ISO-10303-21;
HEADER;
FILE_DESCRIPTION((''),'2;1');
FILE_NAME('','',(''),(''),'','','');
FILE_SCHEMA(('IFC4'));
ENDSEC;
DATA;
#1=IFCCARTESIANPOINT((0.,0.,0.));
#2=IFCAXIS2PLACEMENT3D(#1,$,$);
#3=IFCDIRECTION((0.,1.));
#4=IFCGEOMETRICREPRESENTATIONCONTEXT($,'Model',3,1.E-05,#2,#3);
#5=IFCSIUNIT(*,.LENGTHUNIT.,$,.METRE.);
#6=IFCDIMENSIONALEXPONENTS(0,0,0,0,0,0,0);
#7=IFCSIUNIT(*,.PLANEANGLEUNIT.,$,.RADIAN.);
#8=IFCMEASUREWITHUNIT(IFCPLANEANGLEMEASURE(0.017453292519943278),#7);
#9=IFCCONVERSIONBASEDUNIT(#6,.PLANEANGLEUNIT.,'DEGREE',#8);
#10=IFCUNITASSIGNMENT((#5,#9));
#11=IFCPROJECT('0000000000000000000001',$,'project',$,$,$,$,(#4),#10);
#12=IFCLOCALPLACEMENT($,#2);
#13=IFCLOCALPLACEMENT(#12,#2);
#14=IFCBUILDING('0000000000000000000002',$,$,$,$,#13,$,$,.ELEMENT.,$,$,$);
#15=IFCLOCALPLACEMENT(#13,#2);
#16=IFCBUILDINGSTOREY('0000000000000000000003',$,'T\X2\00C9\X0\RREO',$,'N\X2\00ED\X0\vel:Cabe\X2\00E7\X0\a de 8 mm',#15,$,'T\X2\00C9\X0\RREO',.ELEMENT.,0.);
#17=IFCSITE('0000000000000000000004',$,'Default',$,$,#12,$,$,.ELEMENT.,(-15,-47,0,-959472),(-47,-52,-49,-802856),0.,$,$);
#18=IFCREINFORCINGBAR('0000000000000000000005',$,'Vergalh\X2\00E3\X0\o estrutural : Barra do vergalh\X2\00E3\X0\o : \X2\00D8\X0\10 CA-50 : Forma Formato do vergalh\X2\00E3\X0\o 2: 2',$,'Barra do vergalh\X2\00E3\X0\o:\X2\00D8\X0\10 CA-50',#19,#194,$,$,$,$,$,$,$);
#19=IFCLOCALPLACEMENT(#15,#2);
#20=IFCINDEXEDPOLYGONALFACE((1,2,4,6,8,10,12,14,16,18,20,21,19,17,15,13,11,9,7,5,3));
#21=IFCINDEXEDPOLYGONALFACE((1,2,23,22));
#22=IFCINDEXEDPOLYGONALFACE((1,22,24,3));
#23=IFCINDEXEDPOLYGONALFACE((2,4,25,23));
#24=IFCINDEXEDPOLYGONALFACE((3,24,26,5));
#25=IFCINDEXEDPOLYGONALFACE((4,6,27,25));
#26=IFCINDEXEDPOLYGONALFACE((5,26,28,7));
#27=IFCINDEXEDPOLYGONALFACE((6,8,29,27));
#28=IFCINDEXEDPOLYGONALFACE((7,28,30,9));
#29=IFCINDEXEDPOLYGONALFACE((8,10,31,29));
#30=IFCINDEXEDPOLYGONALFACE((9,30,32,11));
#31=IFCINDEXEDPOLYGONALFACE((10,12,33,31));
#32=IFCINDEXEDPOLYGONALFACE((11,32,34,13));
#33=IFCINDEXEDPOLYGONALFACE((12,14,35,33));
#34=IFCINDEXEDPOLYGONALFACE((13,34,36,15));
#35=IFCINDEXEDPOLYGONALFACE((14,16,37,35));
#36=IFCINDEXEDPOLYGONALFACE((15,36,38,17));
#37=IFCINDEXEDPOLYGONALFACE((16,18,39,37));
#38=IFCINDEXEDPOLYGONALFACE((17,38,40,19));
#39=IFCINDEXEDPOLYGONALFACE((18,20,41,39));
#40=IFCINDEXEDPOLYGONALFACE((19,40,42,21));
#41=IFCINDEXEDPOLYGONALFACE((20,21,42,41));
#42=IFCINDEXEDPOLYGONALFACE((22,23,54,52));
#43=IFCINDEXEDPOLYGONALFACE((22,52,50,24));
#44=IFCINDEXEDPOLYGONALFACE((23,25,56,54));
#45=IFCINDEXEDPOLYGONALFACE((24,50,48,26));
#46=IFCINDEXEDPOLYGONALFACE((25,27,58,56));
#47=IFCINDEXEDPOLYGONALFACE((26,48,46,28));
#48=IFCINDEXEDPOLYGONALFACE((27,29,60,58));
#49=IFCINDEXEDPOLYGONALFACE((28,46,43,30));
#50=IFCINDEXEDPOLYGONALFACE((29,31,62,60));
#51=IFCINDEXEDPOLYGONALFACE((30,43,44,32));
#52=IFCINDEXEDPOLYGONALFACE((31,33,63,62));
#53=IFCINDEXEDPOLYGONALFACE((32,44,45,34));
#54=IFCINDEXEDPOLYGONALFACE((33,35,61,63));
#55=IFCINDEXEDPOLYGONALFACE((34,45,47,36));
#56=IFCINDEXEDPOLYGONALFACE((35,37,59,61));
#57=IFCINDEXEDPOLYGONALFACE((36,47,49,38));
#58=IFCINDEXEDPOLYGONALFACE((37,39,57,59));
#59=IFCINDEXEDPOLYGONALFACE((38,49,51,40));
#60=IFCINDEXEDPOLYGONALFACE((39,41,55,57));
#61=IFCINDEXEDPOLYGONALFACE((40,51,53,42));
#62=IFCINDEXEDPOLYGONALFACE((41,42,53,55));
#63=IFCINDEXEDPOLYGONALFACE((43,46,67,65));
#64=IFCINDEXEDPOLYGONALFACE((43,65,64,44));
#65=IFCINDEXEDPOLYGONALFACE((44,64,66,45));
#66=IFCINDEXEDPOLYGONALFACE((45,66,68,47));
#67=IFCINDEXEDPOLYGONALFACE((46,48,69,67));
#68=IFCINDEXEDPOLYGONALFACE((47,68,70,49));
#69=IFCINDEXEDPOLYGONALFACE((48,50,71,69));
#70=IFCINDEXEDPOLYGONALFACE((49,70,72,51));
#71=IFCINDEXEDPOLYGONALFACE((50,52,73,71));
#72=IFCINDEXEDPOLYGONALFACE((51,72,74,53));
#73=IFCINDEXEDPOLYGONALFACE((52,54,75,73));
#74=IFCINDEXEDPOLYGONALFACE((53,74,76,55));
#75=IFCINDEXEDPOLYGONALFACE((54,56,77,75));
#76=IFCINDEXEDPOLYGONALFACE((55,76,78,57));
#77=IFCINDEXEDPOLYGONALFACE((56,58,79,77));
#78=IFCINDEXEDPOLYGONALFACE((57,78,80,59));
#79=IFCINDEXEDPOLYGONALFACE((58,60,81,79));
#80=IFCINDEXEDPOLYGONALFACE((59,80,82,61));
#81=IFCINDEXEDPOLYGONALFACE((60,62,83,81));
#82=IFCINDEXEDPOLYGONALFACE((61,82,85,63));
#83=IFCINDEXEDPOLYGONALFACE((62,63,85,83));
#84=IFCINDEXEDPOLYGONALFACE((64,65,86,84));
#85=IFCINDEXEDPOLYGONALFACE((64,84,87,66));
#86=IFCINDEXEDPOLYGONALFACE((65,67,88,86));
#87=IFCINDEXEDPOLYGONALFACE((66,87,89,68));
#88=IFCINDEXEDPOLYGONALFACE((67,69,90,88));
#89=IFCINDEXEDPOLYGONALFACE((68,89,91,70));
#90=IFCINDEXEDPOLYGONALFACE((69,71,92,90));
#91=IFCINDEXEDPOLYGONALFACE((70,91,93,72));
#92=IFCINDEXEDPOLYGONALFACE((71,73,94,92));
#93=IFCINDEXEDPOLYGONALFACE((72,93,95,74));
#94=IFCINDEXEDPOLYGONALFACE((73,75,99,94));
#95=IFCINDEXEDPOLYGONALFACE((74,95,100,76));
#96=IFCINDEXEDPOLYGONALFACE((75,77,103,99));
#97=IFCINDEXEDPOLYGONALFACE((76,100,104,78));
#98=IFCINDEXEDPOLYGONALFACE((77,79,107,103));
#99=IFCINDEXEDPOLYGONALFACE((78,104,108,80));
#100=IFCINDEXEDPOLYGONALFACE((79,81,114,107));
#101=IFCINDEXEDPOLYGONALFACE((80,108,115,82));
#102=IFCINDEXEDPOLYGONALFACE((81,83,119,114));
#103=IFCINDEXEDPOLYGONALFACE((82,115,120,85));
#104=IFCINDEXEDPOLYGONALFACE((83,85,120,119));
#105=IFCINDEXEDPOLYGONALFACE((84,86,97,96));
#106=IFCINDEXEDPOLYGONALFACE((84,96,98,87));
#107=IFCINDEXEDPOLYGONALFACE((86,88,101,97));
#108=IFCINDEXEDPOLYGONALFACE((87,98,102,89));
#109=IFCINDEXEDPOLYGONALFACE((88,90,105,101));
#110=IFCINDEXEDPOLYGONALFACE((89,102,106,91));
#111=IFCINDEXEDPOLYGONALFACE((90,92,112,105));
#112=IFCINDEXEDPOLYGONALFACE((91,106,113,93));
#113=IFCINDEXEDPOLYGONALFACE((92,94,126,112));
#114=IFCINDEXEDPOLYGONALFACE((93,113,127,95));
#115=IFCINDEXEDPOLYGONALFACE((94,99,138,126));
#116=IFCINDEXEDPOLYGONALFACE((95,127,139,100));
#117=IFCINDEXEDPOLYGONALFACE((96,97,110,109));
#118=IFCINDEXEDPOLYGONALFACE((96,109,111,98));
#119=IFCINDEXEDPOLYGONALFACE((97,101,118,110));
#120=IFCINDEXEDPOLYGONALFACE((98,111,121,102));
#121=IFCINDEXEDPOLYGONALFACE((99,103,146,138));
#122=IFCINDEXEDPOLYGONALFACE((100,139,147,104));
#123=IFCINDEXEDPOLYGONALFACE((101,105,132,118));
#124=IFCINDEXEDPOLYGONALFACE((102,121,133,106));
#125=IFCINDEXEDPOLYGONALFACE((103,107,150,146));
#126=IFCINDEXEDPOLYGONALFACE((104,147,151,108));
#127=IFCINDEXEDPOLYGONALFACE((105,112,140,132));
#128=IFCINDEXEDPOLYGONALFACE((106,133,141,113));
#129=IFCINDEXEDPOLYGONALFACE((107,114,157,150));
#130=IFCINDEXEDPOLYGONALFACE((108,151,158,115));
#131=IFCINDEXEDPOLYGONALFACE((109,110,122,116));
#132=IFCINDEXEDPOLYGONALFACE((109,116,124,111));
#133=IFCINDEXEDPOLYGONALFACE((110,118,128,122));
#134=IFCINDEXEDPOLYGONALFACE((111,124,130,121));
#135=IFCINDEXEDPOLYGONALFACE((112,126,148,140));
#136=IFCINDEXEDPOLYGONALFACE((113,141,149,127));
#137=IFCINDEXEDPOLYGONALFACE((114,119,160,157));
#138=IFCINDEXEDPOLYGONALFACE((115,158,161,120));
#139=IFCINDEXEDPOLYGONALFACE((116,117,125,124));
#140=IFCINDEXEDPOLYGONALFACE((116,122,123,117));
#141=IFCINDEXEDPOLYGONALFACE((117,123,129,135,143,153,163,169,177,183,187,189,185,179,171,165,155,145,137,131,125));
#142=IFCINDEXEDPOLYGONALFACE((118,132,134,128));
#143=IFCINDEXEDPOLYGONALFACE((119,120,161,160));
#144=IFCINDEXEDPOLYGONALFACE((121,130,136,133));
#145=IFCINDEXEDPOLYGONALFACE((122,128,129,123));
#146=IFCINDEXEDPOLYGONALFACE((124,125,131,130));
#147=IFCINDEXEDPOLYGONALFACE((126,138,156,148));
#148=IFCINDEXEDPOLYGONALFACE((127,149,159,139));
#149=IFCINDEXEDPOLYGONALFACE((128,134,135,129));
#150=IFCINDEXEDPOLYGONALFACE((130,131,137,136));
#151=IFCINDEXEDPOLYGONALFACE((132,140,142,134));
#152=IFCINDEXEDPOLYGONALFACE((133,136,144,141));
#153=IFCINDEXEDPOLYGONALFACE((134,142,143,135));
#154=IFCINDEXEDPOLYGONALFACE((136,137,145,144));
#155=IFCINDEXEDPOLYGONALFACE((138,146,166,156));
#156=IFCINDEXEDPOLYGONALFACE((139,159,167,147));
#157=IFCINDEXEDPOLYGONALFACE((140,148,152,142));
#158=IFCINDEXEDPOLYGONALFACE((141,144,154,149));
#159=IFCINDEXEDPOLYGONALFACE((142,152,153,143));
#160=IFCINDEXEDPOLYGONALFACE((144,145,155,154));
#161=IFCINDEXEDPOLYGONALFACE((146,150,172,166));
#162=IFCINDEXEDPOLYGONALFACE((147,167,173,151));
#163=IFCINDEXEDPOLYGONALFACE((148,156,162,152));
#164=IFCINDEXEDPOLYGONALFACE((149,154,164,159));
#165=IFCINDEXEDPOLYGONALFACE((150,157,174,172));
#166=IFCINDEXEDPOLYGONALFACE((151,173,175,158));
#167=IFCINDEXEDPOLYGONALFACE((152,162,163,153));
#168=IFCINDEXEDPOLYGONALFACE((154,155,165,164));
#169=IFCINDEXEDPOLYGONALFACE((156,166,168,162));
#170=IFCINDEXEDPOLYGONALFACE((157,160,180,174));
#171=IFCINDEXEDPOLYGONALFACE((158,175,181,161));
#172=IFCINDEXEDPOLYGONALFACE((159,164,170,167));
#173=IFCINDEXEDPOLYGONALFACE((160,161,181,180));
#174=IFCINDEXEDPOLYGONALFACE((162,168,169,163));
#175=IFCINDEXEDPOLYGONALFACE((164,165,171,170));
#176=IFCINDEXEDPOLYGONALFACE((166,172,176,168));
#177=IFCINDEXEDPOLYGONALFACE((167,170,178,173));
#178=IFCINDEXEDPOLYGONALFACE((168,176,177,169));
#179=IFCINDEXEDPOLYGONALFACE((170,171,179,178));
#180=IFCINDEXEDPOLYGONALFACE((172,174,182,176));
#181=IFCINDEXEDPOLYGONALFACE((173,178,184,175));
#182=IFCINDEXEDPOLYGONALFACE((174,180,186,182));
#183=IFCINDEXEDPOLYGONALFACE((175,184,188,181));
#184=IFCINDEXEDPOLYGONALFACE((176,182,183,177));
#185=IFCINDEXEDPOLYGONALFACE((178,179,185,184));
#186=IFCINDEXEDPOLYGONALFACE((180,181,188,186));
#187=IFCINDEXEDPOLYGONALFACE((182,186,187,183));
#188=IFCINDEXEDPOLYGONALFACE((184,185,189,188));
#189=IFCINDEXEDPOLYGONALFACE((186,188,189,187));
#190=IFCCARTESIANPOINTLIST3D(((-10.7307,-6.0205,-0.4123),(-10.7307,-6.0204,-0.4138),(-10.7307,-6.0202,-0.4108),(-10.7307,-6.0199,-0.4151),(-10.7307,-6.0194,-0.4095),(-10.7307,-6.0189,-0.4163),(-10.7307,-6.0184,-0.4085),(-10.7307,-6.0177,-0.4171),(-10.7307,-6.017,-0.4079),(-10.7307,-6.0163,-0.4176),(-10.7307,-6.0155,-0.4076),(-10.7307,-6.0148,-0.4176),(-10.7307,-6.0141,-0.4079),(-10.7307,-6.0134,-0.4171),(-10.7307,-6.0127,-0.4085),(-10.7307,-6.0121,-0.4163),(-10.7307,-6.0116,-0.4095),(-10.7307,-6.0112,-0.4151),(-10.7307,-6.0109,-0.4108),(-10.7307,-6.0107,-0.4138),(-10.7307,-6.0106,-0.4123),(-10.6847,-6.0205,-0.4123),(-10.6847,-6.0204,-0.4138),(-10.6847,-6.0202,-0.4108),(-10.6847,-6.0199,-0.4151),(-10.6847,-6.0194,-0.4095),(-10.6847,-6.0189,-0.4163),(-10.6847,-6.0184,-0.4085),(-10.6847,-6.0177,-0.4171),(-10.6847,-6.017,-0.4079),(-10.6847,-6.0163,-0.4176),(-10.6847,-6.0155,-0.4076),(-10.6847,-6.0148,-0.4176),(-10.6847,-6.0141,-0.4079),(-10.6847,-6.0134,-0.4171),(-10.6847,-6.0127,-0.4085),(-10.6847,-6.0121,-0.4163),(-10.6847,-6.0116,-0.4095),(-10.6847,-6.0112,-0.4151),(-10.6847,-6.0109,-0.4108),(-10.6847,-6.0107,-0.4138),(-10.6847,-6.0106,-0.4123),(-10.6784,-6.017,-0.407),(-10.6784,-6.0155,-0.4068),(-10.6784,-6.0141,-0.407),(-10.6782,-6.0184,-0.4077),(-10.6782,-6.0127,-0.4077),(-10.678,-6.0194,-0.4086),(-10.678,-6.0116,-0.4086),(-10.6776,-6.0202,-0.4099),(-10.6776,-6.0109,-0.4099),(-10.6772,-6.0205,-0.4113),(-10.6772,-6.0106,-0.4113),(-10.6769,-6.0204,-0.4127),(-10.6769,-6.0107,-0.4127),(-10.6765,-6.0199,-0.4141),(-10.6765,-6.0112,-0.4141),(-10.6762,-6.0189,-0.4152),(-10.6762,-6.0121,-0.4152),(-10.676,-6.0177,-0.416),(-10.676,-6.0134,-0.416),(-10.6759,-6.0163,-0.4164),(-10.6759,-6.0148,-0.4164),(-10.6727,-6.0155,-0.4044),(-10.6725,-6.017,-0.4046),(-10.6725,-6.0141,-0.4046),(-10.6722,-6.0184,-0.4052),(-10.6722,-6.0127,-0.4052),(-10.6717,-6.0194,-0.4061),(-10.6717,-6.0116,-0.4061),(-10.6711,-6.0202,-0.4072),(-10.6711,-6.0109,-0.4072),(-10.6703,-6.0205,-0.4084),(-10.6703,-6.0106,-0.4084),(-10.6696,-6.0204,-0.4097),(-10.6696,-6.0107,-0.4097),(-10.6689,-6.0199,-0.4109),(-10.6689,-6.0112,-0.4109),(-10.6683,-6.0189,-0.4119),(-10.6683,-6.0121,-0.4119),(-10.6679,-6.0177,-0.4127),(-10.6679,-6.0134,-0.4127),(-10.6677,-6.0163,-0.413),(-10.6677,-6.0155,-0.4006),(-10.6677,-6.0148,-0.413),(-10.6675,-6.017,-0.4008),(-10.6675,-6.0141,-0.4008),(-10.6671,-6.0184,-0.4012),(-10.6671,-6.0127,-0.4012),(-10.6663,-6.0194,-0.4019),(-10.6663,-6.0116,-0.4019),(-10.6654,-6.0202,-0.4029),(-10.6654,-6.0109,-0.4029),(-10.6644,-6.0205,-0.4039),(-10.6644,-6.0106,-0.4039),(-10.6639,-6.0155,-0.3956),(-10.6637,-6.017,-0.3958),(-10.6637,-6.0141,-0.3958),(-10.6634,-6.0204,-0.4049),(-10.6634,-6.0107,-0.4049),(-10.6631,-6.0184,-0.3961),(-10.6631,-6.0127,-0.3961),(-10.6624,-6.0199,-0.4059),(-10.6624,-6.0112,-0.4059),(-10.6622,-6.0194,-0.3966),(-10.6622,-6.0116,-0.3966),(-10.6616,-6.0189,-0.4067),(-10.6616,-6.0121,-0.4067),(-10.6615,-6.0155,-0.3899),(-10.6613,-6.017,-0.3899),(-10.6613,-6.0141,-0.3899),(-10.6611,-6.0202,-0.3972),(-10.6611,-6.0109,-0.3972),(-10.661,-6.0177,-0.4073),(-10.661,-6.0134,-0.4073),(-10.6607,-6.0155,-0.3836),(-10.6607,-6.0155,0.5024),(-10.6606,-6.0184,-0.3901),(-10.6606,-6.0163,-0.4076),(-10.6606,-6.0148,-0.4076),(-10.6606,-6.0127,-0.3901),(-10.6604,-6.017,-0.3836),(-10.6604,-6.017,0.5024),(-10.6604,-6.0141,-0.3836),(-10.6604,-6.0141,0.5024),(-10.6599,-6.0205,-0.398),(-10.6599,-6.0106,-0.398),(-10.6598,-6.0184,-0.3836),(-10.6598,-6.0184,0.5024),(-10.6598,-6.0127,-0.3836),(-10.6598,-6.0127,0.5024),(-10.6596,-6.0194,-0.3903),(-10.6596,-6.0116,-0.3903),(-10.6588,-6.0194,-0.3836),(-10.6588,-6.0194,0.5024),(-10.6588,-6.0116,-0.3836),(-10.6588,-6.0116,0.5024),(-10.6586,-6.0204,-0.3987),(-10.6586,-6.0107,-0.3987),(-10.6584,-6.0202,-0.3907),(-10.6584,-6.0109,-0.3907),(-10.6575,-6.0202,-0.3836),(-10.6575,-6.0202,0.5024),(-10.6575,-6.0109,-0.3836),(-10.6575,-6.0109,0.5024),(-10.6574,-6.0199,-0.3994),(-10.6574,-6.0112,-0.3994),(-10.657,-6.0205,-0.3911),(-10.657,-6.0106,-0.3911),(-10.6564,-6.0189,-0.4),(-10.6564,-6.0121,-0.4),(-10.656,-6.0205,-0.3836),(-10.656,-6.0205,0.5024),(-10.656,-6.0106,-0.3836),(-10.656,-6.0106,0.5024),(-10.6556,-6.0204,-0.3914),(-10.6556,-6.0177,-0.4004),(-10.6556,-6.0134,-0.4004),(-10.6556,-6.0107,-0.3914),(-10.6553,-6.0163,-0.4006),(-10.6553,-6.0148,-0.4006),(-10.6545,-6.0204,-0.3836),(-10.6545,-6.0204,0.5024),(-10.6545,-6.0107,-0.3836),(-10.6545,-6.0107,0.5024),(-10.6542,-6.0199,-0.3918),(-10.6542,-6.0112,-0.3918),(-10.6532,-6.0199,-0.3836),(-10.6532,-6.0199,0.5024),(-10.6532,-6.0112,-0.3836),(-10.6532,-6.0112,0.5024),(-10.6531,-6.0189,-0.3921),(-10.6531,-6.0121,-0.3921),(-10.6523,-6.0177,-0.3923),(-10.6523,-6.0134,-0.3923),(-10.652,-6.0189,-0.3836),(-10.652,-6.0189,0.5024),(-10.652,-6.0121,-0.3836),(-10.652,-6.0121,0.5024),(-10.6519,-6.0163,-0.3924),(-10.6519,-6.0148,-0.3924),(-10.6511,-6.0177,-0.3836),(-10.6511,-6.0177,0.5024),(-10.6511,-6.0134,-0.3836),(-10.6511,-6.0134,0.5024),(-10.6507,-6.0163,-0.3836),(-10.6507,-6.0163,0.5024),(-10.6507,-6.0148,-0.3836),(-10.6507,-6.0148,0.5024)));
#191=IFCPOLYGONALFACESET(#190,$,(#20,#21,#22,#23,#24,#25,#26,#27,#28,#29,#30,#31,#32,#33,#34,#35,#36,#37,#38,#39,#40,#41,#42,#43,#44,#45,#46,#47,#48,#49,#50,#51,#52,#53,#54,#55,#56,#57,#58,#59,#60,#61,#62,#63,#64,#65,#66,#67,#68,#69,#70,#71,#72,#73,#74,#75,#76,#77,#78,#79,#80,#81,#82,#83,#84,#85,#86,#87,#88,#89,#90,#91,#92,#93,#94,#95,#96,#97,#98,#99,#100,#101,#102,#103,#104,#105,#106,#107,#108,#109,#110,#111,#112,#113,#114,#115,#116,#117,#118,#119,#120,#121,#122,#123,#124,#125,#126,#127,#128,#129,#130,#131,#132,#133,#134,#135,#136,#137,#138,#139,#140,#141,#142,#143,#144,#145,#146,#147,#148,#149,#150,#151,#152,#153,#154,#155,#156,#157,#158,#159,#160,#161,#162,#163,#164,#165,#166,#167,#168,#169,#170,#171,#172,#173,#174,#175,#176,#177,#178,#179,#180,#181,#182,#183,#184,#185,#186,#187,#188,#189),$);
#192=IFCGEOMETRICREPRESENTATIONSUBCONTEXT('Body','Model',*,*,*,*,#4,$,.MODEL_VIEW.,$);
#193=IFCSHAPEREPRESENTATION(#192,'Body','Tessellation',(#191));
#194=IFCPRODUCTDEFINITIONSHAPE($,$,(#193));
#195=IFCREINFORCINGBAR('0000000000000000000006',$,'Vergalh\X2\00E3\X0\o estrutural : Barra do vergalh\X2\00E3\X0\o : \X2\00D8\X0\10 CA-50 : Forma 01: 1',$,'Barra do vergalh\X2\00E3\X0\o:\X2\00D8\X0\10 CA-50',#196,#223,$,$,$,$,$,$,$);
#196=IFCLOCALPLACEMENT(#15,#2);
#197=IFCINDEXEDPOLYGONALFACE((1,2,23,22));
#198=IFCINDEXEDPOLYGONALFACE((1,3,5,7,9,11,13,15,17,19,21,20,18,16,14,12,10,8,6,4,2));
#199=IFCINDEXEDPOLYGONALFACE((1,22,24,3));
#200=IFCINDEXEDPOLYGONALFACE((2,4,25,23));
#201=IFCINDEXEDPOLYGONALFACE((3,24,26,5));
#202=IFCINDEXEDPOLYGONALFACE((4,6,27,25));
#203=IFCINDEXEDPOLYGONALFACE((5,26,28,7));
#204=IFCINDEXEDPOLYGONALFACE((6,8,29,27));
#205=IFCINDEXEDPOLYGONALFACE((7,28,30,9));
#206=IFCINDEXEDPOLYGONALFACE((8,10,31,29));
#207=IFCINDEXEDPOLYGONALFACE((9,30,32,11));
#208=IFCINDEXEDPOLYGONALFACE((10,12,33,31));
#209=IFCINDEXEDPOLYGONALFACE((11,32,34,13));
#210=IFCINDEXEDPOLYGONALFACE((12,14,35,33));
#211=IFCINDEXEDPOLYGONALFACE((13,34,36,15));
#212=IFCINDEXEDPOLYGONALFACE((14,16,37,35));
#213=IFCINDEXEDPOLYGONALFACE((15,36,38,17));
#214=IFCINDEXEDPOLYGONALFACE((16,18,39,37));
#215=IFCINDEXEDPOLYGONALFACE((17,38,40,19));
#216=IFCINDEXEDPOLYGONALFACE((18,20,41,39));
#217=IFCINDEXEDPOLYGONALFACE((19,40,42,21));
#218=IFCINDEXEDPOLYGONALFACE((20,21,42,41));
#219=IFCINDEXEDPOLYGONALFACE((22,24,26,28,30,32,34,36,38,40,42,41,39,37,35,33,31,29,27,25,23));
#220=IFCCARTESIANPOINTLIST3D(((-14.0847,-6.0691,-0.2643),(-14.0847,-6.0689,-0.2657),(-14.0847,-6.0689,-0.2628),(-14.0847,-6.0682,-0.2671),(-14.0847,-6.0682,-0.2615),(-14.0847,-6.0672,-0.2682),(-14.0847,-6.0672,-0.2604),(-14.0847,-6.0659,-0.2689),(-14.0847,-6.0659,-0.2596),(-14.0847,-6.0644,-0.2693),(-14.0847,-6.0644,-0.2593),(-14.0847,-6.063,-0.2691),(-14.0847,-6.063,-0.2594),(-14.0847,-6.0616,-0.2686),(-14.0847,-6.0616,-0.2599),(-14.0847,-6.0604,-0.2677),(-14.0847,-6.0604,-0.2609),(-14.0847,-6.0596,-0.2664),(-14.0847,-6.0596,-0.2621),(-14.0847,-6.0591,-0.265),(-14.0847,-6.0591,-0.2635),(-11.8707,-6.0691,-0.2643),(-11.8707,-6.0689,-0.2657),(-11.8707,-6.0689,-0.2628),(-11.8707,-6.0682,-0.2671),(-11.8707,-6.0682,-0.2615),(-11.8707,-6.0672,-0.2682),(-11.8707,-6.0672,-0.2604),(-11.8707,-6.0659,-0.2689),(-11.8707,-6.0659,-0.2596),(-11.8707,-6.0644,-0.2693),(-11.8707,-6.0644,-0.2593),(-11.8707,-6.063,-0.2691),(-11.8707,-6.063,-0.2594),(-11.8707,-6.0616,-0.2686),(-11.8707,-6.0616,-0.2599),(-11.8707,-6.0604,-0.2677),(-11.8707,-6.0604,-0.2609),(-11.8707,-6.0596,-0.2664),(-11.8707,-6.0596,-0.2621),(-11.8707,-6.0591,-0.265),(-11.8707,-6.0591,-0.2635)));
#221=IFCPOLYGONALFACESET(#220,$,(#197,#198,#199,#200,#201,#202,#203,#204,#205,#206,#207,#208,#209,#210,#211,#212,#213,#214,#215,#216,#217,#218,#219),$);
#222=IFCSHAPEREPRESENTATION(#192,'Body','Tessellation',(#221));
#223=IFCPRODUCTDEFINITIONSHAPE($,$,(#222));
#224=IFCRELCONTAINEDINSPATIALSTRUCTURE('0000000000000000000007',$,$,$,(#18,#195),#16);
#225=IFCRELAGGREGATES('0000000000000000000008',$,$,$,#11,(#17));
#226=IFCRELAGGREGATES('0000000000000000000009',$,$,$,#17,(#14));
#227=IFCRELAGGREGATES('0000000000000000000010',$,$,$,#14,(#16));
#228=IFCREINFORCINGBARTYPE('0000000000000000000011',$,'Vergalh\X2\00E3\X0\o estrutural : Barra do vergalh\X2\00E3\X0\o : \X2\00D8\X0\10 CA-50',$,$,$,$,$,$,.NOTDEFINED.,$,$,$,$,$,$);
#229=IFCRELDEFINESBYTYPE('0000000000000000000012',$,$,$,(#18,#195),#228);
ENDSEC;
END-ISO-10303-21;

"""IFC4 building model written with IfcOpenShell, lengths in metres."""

from ifc_helpers import new_model, entity, si_unit, converted_unit, direction, origin, place, context, subcontext, project, spatial, type_object, element, save


model = new_model("IFC4")

# Units and contexts
model_context = context("Model", 3, precision=1e-05, world=origin(), true_north=direction((0.0, 1.0)))
body_context = subcontext(model_context, "Body", "Model", "MODEL_VIEW")
ifc_project = project(units=[si_unit("LENGTHUNIT", "METRE"), converted_unit("PLANEANGLEUNIT", "DEGREE", entity("IfcPlaneAngleMeasure", 0.017453292519943278), si_unit("PLANEANGLEUNIT", "RADIAN"), dimensions=[0, 0, 0, 0, 0, 0, 0])], contexts=[model_context])

# Site, building, storey
site_placement = place(None, origin())
site = spatial("IfcSite", under=ifc_project, at=site_placement, Name="Default", CompositionType="ELEMENT", RefLatitude=(-15, -47, 0, -959472), RefLongitude=(-47, -52, -49, -802856), RefElevation=0.0)
building_placement = place(site_placement, origin())
building = spatial("IfcBuilding", under=site, at=building_placement, CompositionType="ELEMENT")
storey_placement = place(building_placement, origin())
storey = spatial("IfcBuildingStorey", under=building, at=storey_placement, Name="TÉRREO", ObjectType="Nível:Cabeça de 8 mm", LongName="TÉRREO", CompositionType="ELEMENT", Elevation=0.0)

# Reinforcing bars
reinforcing_bar_type_1 = type_object("IfcReinforcingBarType", Name="Vergalhão estrutural : Barra do vergalhão : Ø10 CA-50", PredefinedType="NOTDEFINED")
reinforcing_bar_1_placement = place(storey_placement, origin())
element("IfcReinforcingBar", 1, at=reinforcing_bar_1_placement, inside=storey, type_object=reinforcing_bar_type_1, Name="Vergalhão estrutural : Barra do vergalhão : Ø10 CA-50 : Forma Formato do vergalhão 2: 2", ObjectType="Barra do vergalhão:Ø10 CA-50", context=body_context, shape_type="AdvancedSweptSolid", body=[
    entity("IfcSweptDiskSolid", entity("IfcIndexedPolyCurve", entity("IfcCartesianPointList3D", [[-10.7307, -6.0155, -0.4126], [-10.6847, -6.0155, -0.4126], [-10.6641, -6.0155, -0.4042], [-10.6557, -6.0155, -0.3836], [-10.6557, -6.0155, 0.5024]]), [entity("IfcLineIndex", [1, 2]), entity("IfcArcIndex", [2, 3, 4]), entity("IfcLineIndex", [4, 5])], False), 0.005, None, 0.0, 92.0),
])
reinforcing_bar_2_placement = place(storey_placement, origin())
element("IfcReinforcingBar", 2, at=reinforcing_bar_2_placement, inside=storey, type_object=reinforcing_bar_type_1, Name="Vergalhão estrutural : Barra do vergalhão : Ø10 CA-50 : Forma 01: 1", ObjectType="Barra do vergalhão:Ø10 CA-50", context=body_context, shape_type="AdvancedSweptSolid", body=[
    entity("IfcSweptDiskSolid", entity("IfcIndexedPolyCurve", entity("IfcCartesianPointList3D", [[-11.8707, -6.0641, -0.2643], [-14.0847, -6.0641, -0.2643]]), None, False), 0.005, None, 0.0, 1.0),
])

save(model, "model.ifc")
